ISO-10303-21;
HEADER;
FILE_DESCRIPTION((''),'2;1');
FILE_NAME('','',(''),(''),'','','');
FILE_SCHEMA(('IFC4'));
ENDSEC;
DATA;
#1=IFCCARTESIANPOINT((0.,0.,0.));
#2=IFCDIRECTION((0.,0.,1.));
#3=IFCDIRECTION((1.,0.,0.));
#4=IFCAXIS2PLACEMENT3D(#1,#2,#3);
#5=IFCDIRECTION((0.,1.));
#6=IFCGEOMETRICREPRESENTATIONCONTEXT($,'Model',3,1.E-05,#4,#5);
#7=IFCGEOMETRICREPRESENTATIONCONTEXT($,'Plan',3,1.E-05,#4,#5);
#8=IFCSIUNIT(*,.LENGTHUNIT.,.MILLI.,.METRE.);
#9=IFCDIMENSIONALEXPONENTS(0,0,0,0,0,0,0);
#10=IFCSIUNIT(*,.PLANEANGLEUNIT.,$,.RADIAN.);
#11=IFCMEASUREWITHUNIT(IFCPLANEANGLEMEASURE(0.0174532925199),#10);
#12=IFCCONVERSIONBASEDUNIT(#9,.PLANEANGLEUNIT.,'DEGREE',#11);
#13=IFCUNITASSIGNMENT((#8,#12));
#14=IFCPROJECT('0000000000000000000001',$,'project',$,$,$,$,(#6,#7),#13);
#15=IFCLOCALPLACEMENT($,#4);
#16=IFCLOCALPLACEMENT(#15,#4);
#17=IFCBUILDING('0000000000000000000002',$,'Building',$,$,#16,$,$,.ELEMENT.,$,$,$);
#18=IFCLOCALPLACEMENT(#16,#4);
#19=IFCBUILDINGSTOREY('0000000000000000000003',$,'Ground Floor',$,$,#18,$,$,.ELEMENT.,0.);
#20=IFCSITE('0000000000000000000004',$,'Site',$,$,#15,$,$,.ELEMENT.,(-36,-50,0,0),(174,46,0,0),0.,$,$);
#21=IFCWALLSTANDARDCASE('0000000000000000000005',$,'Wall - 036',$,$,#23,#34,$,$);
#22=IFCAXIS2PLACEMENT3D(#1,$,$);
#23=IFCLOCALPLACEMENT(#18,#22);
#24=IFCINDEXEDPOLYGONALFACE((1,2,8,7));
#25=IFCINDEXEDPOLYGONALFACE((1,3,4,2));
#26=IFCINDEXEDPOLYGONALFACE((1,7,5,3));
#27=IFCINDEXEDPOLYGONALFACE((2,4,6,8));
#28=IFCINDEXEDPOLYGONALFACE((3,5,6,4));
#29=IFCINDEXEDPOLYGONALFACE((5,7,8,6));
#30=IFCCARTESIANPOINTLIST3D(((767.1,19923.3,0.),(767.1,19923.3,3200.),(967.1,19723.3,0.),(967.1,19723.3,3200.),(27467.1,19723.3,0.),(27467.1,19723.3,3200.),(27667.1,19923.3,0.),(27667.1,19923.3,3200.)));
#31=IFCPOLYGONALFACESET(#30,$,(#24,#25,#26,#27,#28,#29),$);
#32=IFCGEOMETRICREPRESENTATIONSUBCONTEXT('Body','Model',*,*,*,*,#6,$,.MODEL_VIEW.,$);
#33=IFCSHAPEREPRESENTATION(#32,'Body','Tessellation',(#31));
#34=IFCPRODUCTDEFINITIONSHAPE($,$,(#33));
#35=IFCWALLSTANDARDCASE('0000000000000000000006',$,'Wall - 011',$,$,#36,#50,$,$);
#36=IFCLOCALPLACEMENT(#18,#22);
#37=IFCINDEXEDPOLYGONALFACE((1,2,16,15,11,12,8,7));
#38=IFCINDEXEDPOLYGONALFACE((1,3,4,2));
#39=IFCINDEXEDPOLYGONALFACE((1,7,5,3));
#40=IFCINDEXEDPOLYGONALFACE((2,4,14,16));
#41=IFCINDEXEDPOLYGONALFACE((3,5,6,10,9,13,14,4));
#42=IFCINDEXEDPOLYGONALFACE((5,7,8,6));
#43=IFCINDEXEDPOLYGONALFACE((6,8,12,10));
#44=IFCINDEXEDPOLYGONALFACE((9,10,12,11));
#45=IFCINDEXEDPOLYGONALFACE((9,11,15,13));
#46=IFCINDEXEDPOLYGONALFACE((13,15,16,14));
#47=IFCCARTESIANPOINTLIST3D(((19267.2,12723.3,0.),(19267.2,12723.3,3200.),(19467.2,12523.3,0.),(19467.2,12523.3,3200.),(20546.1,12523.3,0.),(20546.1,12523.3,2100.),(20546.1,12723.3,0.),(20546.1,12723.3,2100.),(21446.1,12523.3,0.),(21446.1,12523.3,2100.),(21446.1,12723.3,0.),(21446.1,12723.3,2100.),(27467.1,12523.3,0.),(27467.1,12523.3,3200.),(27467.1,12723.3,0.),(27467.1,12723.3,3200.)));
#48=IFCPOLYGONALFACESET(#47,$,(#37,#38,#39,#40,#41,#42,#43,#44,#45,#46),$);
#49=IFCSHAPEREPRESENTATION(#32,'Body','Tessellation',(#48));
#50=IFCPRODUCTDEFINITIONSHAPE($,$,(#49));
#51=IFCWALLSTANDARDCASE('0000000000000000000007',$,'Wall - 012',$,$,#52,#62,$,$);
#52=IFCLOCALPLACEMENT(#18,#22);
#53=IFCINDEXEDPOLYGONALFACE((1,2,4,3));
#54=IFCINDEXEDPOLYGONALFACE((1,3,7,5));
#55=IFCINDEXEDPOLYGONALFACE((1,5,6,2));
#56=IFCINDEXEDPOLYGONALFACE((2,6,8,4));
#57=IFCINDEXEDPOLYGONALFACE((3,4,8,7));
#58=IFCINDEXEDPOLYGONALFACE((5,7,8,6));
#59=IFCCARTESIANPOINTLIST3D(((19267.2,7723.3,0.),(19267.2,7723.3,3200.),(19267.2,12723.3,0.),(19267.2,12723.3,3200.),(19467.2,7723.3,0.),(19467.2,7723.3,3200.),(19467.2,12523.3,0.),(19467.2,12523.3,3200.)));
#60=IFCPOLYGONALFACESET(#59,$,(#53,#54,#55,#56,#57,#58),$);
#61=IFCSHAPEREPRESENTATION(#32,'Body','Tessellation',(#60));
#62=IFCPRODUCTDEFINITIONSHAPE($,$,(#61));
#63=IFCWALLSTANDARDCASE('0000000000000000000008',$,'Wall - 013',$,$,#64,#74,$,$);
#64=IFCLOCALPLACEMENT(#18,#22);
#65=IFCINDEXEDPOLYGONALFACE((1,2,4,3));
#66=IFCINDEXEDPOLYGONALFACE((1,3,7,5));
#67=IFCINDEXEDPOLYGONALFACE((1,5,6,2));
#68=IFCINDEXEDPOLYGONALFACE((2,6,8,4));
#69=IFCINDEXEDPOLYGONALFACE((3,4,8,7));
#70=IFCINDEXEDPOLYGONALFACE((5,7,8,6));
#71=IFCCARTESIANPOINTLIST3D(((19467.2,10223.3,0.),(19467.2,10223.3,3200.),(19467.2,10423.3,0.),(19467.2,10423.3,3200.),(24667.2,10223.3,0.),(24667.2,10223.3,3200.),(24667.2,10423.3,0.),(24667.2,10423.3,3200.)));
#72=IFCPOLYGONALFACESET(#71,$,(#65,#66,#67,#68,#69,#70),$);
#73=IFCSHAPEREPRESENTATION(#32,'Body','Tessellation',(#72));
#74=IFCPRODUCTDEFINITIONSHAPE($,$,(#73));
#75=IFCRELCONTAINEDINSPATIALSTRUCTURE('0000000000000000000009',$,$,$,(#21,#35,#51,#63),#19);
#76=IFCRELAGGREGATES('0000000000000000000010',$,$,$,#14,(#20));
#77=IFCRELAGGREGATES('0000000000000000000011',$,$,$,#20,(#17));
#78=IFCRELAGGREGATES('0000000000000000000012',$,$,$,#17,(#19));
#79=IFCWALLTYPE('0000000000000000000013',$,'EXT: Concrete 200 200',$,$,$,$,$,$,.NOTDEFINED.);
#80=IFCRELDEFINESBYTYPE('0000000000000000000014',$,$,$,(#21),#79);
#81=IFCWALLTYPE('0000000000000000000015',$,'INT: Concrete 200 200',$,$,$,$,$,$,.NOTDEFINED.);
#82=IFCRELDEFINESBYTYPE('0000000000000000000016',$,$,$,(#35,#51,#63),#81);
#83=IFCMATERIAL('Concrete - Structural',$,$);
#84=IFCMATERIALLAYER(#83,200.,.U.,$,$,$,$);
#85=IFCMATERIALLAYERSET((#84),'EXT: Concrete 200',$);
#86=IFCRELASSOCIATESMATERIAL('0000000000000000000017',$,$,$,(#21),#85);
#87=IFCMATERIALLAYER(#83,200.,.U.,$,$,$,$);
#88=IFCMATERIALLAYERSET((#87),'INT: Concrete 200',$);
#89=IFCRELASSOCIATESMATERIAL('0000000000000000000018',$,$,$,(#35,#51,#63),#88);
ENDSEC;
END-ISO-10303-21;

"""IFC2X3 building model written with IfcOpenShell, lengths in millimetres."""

from ifc_helpers import new_model, entity, si_unit, converted_unit, direction, frame, origin_with_axes, origin_2d_with_axis, place, context, subcontext, project, spatial, polyline, rectangle, outline, extrude, material, layer, layer_set, layer_usage, type_object, element, save


model = new_model("IFC2X3")

# Units and contexts
model_context = context("Model", 3, precision=1e-05, world=origin_with_axes(), true_north=direction((0.0, 1.0)))
plan_context = context("Plan", 3, precision=1e-05, world=origin_with_axes(), true_north=direction((0.0, 1.0)))
body_context = subcontext(model_context, "Body", "Model", "MODEL_VIEW")
ifc_project = project(units=[si_unit("LENGTHUNIT", "METRE", prefix="MILLI"), converted_unit("PLANEANGLEUNIT", "DEGREE", entity("IfcPlaneAngleMeasure", 0.0174532925199), si_unit("PLANEANGLEUNIT", "RADIAN"), dimensions=[0, 0, 0, 0, 0, 0, 0])], contexts=[model_context, plan_context])

# Site, building, storey
site_placement = place(None, origin_with_axes())
site = spatial("IfcSite", under=ifc_project, at=site_placement, Name="Site", CompositionType="ELEMENT", RefLatitude=(-36, -50, 0, 0), RefLongitude=(174, 46, 0, 0), RefElevation=0.0)
building_placement = place(site_placement, origin_with_axes())
building = spatial("IfcBuilding", under=site, at=building_placement, Name="Building", CompositionType="ELEMENT")
storey_placement = place(building_placement, origin_with_axes())
storey = spatial("IfcBuildingStorey", under=building, at=storey_placement, Name="Ground Floor", CompositionType="ELEMENT", Elevation=0.0)

# Shared definitions
ifc_material_1 = material(Name="Concrete - Structural")

# Shared definitions
ifc_layer_1 = layer(ifc_material_1, 200.0, ventilated="UNKNOWN")
ifc_layer_set_1 = layer_set([ifc_layer_1], Name="EXT: Concrete 200")
wall_type_1 = type_object("IfcWallType", Name="EXT: Concrete 200 200", PredefinedType="NOTDEFINED")

# Wall
ifc_layer_usage_1 = layer_usage(ifc_layer_set_1, "AXIS2", "POSITIVE", -200.0)
wall_1_placement = place(storey_placement, frame((767.1, 19923.3, 0.0), z_axis=(0.0, 0.0, 1.0), x_axis=(1.0, 0.0, 0.0)))
element("IfcWallStandardCase", 1, at=wall_1_placement, inside=storey, type_object=wall_type_1, material=ifc_layer_usage_1, Name="Wall - 036", context=body_context, shape_type="SweptSolid", body=[
    extrude(outline(polyline([(200.0, -200.0), (26700.0, -200.0), (26900.0, 0.0), (0.0, 0.0), (200.0, -200.0)])), origin_with_axes(), (0.0, 0.0, 1.0), 3200.0),
])

# Wall, opening
ifc_layer_2 = layer(ifc_material_1, 200.0, ventilated="UNKNOWN")
ifc_layer_set_2 = layer_set([ifc_layer_2], Name="INT: Concrete 200")
ifc_layer_usage_2 = layer_usage(ifc_layer_set_2, "AXIS2", "POSITIVE", -200.0)
wall_type_2 = type_object("IfcWallType", Name="INT: Concrete 200 200", PredefinedType="NOTDEFINED")
wall_2_placement = place(storey_placement, frame((27667.1, 12523.3, 0.0), z_axis=(0.0, 0.0, 1.0), x_axis=(-1.0, 0.0, 0.0)))
wall_2 = element("IfcWallStandardCase", 2, at=wall_2_placement, inside=storey, type_object=wall_type_2, material=ifc_layer_usage_2, Name="Wall - 011", context=body_context, shape_type="SweptSolid", body=[
    extrude(outline(polyline([(200.0, -200.0), (8399.9, -200.0), (8199.9, 0.0), (200.0, 0.0), (200.0, -200.0)])), origin_with_axes(), (0.0, 0.0, 1.0), 3200.0),
])
opening_1_placement = place(wall_2_placement, frame((6671.0, 0.0, 0.0), z_axis=(0.0, 0.0, 1.0), x_axis=(1.0, 0.0, 0.0)))
element("IfcOpeningElement", 3, at=opening_1_placement, cuts=wall_2, context=body_context, shape_type="SweptSolid", body=[
    extrude(rectangle(XDim=900.0, YDim=2100.0, at=origin_2d_with_axis()), frame((0.0, -200.0, 1050.0), z_axis=(0.0, 1.0, 0.0), x_axis=(1.0, 0.0, 0.0)), (0.0, 0.0, 1.0), 600.0),
])

# Walls
ifc_layer_usage_3 = layer_usage(ifc_layer_set_2, "AXIS2", "POSITIVE", 0.0)
wall_3_placement = place(storey_placement, frame((19267.2, 12523.3, 0.0), z_axis=(0.0, 0.0, 1.0), x_axis=(0.0, -1.0, 0.0)))
element("IfcWallStandardCase", 4, at=wall_3_placement, inside=storey, type_object=wall_type_2, material=ifc_layer_usage_3, Name="Wall - 012", context=body_context, shape_type="SweptSolid", body=[
    extrude(outline(polyline([(-200.0, 0.0), (4800.0, 0.0), (4800.0, 200.0), (0.0, 200.0), (-200.0, 0.0)])), origin_with_axes(), (0.0, 0.0, 1.0), 3200.0),
])
ifc_layer_usage_4 = layer_usage(ifc_layer_set_2, "AXIS2", "POSITIVE", -200.0)
wall_4_placement = place(storey_placement, frame((19467.2, 10423.3, 0.0), z_axis=(0.0, 0.0, 1.0), x_axis=(1.0, 0.0, 0.0)))
element("IfcWallStandardCase", 5, at=wall_4_placement, inside=storey, type_object=wall_type_2, material=ifc_layer_usage_4, Name="Wall - 013", context=body_context, shape_type="SweptSolid", body=[
    extrude(outline(polyline([(0.0, -200.0), (5200.0, -200.0), (5200.0, 0.0), (0.0, 0.0), (0.0, -200.0)])), origin_with_axes(), (0.0, 0.0, 1.0), 3200.0),
])

save(model, "model.ifc")
